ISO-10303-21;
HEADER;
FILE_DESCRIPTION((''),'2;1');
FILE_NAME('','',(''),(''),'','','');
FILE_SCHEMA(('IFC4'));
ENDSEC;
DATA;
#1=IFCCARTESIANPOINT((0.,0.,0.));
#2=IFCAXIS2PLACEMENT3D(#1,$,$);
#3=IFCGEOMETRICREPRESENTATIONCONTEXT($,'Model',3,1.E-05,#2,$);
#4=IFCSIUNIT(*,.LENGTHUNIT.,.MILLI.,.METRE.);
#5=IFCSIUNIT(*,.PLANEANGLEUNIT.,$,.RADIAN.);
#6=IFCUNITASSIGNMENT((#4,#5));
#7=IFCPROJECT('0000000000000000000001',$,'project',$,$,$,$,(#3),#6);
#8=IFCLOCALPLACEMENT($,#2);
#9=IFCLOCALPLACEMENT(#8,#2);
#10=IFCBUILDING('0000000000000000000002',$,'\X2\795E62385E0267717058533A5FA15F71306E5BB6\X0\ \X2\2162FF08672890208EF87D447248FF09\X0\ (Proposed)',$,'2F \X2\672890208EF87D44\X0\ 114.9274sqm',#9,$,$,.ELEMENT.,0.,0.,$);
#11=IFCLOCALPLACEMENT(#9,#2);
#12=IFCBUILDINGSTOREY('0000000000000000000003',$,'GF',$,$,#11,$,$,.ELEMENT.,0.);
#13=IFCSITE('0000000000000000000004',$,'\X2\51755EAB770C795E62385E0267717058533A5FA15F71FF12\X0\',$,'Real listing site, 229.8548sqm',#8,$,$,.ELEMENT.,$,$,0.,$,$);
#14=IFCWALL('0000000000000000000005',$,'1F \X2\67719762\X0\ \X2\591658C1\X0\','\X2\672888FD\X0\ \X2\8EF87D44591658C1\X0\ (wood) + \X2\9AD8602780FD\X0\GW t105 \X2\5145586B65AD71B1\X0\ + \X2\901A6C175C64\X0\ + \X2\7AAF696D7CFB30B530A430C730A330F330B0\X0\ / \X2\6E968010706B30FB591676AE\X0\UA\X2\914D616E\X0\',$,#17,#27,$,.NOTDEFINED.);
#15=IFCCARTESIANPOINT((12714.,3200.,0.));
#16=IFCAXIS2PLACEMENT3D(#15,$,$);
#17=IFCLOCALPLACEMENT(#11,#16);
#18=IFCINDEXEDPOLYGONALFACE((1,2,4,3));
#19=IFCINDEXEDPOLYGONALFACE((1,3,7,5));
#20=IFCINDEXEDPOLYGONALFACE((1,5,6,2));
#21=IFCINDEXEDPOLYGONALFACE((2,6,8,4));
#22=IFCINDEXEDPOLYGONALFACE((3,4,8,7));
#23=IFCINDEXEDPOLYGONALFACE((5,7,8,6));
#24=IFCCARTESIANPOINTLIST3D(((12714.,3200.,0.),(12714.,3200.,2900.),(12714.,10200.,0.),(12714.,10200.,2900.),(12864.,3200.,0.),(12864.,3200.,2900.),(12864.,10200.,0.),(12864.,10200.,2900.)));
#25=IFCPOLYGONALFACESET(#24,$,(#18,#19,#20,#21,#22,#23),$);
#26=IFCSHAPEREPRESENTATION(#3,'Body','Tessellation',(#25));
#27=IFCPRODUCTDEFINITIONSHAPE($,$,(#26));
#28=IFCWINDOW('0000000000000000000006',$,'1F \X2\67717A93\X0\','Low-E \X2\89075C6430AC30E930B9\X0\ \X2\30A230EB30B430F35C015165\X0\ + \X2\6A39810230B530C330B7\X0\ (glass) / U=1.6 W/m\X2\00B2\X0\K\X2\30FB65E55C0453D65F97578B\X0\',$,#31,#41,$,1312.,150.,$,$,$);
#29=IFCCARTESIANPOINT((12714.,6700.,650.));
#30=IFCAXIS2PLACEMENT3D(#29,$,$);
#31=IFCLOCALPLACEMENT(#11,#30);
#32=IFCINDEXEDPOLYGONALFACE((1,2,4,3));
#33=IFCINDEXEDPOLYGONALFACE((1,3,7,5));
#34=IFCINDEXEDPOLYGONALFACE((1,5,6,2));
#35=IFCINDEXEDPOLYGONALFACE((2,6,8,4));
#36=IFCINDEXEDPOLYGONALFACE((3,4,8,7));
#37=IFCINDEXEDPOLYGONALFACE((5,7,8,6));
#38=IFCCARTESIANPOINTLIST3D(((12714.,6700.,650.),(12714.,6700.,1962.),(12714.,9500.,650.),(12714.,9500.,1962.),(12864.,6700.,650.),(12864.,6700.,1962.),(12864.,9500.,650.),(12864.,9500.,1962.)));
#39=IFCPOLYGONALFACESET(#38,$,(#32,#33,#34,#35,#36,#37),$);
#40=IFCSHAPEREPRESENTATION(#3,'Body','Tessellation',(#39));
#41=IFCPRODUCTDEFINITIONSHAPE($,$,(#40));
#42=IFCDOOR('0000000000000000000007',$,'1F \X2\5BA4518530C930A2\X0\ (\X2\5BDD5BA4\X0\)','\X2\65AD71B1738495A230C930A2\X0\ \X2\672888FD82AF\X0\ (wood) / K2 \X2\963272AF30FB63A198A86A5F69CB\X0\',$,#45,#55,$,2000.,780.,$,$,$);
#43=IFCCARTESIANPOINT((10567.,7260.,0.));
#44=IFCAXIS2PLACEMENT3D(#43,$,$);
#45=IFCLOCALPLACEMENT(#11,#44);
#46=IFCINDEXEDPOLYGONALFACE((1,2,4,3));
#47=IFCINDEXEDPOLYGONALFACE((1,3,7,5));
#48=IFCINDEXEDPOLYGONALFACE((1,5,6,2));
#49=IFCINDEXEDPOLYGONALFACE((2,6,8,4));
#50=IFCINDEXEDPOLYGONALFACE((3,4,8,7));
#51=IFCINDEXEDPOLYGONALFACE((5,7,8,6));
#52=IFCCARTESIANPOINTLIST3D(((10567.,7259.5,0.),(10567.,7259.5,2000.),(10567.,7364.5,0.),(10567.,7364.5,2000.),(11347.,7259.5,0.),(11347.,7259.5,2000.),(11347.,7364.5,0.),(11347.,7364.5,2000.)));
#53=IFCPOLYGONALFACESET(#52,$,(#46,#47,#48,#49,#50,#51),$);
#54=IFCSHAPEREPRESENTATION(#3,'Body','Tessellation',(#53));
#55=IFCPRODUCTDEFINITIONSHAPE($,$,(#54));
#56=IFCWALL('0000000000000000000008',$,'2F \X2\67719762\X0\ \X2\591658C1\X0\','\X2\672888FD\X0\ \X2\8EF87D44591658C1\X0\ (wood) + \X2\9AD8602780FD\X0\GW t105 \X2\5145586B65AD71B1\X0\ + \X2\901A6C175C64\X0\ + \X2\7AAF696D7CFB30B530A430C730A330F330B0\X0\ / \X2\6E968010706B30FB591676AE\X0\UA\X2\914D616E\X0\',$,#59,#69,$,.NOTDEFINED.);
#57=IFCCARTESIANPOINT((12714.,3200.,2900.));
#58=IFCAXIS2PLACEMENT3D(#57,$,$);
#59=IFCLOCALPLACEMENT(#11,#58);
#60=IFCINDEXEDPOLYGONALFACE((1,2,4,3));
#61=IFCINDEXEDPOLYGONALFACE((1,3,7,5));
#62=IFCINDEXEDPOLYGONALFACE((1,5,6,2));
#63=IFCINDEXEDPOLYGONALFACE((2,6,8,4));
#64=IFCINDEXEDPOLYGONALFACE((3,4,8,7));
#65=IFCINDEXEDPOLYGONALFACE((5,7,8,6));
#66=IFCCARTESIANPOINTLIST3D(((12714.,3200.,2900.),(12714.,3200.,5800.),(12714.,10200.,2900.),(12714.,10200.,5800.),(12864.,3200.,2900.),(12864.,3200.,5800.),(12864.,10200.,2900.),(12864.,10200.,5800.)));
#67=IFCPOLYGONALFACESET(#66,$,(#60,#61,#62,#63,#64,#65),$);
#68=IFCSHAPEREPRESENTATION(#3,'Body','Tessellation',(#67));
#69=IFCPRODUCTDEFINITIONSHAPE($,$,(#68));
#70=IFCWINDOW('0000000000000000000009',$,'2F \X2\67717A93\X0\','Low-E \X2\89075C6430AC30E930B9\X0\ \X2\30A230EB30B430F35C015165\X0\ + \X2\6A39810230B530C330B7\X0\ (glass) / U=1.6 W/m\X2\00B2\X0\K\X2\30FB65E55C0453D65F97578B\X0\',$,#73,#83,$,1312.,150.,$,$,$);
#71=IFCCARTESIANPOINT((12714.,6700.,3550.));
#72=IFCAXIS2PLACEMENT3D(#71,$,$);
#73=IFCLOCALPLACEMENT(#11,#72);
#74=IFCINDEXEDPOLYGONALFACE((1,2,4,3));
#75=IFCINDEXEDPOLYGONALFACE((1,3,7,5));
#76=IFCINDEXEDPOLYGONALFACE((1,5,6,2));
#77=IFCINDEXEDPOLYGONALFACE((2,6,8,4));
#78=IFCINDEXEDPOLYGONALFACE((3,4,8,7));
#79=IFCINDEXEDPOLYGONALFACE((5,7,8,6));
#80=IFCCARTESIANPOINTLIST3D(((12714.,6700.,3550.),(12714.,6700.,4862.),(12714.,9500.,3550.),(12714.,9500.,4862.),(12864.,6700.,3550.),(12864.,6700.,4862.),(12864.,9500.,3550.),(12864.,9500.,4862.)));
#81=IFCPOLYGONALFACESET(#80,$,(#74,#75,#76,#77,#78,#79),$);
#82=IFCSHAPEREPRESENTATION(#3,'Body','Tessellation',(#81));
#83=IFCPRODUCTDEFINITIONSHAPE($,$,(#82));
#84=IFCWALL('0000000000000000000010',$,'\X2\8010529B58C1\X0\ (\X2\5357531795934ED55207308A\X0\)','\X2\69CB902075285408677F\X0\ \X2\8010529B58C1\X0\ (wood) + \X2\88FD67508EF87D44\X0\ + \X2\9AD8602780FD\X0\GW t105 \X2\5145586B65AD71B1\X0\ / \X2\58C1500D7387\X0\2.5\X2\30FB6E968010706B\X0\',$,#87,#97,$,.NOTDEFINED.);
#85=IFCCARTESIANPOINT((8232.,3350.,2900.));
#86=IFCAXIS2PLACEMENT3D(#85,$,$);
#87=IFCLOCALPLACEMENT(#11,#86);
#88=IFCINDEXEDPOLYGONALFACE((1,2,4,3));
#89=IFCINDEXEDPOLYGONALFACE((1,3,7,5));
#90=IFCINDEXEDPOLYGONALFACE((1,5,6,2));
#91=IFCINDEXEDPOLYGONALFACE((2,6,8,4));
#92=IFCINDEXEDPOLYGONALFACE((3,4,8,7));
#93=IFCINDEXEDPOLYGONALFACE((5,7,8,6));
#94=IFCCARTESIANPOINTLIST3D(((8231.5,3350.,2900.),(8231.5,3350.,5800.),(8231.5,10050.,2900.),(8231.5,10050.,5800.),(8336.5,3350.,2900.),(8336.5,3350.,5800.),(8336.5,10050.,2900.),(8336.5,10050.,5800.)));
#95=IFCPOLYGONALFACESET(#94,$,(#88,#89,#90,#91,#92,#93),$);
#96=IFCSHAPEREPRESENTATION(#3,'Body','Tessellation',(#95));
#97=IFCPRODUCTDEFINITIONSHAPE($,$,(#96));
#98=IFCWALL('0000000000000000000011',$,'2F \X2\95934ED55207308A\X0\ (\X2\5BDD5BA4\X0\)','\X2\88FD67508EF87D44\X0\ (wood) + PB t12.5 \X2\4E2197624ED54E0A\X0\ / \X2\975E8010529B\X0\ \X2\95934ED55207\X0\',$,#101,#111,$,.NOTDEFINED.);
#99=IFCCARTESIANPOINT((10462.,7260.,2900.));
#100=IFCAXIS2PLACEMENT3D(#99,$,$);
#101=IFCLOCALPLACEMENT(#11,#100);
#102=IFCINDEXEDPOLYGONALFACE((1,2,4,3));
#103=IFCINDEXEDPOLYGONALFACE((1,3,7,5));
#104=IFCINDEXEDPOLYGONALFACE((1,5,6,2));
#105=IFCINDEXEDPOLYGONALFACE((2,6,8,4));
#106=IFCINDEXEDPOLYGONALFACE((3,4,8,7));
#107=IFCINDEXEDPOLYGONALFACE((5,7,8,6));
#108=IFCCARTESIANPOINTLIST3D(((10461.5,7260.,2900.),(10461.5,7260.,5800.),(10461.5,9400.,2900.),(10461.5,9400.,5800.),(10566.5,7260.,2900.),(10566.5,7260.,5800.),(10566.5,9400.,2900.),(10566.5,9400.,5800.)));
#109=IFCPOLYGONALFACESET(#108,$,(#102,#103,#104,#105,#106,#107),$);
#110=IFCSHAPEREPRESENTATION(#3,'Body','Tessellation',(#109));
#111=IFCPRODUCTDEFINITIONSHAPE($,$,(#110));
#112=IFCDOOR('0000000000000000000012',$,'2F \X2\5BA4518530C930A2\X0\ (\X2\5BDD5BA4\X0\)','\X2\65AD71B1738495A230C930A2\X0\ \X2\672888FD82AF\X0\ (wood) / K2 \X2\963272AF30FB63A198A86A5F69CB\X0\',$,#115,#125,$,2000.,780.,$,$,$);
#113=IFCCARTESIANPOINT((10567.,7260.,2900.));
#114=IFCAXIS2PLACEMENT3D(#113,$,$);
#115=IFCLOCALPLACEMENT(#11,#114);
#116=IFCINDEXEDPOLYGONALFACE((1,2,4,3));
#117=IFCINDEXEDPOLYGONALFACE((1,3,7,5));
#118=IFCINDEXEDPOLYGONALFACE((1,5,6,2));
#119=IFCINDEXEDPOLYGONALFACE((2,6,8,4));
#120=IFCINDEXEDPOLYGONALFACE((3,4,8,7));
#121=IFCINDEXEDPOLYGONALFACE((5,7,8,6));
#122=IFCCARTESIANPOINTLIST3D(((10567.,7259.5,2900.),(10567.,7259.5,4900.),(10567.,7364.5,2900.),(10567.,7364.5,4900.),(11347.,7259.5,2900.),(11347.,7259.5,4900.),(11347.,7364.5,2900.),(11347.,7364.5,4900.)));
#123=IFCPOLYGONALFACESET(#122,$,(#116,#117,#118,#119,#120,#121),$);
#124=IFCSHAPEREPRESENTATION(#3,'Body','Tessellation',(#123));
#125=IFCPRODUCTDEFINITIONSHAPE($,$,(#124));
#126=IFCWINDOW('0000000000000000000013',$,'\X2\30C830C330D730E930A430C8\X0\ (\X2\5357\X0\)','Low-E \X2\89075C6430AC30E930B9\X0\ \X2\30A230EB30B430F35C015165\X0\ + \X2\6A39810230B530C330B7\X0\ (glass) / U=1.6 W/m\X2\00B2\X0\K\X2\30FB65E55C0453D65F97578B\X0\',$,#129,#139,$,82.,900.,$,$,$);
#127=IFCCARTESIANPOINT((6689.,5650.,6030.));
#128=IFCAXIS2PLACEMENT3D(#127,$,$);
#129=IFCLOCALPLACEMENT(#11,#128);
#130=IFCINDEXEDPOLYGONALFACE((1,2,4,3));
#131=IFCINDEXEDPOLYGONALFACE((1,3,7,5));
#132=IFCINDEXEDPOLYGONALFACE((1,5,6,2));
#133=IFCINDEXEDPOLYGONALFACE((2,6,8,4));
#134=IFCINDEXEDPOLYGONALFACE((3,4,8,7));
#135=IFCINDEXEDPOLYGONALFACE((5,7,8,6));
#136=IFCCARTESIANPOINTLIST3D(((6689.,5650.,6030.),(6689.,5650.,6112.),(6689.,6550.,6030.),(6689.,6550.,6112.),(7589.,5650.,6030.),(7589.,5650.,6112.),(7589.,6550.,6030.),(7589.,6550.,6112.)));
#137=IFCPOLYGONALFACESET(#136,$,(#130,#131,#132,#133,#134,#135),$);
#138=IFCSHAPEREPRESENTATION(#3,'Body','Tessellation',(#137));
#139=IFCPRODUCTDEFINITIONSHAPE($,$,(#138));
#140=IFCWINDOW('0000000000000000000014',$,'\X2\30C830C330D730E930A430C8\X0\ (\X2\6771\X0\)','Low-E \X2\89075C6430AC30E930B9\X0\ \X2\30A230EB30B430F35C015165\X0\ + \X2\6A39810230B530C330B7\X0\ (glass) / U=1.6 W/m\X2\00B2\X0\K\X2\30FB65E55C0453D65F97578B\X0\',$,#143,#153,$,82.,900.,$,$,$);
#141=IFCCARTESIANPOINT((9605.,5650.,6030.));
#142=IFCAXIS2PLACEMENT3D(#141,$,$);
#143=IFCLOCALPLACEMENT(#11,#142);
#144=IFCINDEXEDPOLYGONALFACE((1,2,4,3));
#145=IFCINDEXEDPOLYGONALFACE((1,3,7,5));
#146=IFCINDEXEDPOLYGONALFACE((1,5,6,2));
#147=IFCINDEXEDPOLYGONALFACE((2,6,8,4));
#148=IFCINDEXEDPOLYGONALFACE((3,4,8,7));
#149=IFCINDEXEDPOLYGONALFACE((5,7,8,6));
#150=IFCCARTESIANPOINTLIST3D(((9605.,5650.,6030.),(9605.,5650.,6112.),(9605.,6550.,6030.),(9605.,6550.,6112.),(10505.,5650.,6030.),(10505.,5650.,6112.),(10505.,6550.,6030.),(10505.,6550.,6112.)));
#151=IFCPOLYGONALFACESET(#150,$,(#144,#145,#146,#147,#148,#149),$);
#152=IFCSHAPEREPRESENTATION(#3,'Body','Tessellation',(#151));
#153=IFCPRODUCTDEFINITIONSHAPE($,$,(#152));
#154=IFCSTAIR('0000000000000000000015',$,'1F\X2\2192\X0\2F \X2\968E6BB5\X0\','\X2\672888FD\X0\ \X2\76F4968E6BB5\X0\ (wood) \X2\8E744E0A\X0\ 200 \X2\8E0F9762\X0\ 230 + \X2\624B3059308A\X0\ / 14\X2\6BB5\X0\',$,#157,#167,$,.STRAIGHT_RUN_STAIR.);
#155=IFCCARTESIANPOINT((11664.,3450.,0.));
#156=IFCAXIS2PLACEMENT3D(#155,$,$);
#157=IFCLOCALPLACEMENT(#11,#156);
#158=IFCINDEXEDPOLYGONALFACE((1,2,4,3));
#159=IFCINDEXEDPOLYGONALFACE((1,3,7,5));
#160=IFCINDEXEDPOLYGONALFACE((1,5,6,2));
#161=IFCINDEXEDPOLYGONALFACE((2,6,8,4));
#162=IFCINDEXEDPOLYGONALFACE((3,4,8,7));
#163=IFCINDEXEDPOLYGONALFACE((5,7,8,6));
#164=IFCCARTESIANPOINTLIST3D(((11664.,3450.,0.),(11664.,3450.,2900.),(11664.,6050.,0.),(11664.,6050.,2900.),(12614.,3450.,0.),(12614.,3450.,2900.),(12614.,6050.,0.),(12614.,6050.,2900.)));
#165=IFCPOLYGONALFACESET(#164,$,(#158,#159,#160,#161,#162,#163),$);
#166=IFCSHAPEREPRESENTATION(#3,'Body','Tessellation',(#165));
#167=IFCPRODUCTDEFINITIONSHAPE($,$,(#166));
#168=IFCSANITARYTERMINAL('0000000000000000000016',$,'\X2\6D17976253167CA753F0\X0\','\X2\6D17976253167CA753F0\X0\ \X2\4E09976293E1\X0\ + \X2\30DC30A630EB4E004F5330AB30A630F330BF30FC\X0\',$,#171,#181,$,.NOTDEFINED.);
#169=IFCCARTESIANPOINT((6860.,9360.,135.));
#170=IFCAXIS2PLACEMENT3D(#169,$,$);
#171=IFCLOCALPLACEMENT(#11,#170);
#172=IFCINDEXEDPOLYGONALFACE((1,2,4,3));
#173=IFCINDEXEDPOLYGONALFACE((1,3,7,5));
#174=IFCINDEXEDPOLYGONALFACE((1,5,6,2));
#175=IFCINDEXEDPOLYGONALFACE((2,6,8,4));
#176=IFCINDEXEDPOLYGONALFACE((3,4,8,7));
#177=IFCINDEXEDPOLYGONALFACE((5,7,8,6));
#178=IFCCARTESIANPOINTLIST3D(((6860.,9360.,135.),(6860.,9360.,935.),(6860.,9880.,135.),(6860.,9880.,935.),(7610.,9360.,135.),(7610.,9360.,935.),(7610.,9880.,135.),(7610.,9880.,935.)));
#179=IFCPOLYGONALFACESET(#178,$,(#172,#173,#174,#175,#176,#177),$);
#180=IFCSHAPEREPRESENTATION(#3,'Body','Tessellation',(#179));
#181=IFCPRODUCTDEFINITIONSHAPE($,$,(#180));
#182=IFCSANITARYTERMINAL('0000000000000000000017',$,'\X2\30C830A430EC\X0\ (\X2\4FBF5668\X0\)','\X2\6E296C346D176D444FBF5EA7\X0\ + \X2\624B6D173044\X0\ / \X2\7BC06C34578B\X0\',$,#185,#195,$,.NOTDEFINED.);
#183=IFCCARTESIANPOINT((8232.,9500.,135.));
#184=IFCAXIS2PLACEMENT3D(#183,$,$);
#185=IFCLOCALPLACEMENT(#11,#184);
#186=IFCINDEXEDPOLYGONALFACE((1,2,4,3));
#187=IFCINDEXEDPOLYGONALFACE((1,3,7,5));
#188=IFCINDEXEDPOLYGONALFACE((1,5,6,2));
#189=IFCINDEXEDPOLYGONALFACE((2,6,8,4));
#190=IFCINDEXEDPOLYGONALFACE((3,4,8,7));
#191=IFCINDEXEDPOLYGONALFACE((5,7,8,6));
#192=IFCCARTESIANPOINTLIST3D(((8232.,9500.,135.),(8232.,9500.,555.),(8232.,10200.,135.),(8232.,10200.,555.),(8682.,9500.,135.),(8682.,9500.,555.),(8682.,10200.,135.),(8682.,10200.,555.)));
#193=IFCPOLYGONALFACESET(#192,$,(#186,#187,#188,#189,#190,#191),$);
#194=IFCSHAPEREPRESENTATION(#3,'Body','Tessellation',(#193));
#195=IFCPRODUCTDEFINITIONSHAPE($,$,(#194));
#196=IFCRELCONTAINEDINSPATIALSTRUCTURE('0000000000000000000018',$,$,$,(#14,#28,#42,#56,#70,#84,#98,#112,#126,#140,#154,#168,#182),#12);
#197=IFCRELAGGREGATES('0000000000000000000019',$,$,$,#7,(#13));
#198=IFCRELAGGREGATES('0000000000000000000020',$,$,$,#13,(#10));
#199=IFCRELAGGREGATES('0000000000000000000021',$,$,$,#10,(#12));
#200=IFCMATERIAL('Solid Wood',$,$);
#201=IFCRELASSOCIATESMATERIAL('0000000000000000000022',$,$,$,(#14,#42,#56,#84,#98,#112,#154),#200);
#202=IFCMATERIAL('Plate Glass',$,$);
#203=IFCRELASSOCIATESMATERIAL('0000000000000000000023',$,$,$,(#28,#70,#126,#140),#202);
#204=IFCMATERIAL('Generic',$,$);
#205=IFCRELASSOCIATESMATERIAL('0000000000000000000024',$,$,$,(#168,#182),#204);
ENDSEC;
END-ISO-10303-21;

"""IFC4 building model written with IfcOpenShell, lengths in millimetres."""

from ifc_helpers import new_model, si_unit, frame, frame_2d, origin, place, context, project, spatial, rectangle, extrude, material, element, fill, save


model = new_model("IFC4")

# Units and contexts
model_context = context("Model", 3, precision=1e-05, world=origin())
ifc_project = project(units=[si_unit("LENGTHUNIT", "METRE", prefix="MILLI"), si_unit("PLANEANGLEUNIT", "RADIAN")], contexts=[model_context])

# Site, building, storey
site_placement = place(None, origin())
site = spatial("IfcSite", under=ifc_project, at=site_placement, Name="兵庫県神戸市東灘区御影２", ObjectType="Real listing site, 229.8548sqm", CompositionType="ELEMENT", RefElevation=0.0)
building_placement = place(site_placement, origin())
building = spatial("IfcBuilding", under=site, at=building_placement, Name="神戸市東灘区御影の家 Ⅲ（木造軸組版） (Proposed)", ObjectType="2F 木造軸組 114.9274sqm", CompositionType="ELEMENT", ElevationOfRefHeight=0.0, ElevationOfTerrain=0.0)
storey_placement = place(building_placement, origin())
storey = spatial("IfcBuildingStorey", under=building, at=storey_placement, Name="GF", CompositionType="ELEMENT", Elevation=0.0)

# Wall, opening, window
ifc_material_1 = material(Name="Solid Wood")
wall_1_placement = place(storey_placement, frame((12714.0, 3200.0, 0.0)))
wall_1 = element("IfcWall", 1, at=wall_1_placement, inside=storey, material=ifc_material_1, Name="1F 東面 外壁", Description="木製 軸組外壁 (wood) + 高性能GW t105 充填断熱 + 通気層 + 窯業系サイディング / 準耐火・外皮UA配慮", PredefinedType="NOTDEFINED", context=model_context, shape_type="SweptSolid", body=[
    extrude(rectangle(XDim=150.0, YDim=7000.0, at=frame_2d((75.0, 3500.0))), frame((12714.0, 3200.0, 0.0)), (0.0, 0.0, 1.0), 2900.0),
])
opening_1_placement = place(storey_placement, frame((12714.0, 6700.0, 650.0)))
opening_1 = element("IfcOpeningElement", 2, at=opening_1_placement, cuts=wall_1, PredefinedType="NOTDEFINED", context=model_context, shape_type="SweptSolid", body=[
    extrude(rectangle(XDim=150.0, YDim=2800.0, at=frame_2d((75.0, 1400.0))), frame((12714.0, 6700.0, 650.0)), (0.0, 0.0, 1.0), 1312.0),
])
ifc_material_2 = material(Name="Plate Glass")
window_1_placement = place(storey_placement, frame((12714.0, 6700.0, 650.0)))
window_1 = element("IfcWindow", 3, at=window_1_placement, inside=storey, material=ifc_material_2, Name="1F 東窓", Description="Low-E 複層ガラス アルゴン封入 + 樹脂サッシ (glass) / U=1.6 W/m²K・日射取得型", OverallHeight=1312.0, OverallWidth=150.0, context=model_context, shape_type="SweptSolid", body=[
    extrude(rectangle(XDim=150.0, YDim=2800.0, at=frame_2d((75.0, 1400.0))), frame((12714.0, 6700.0, 650.0)), (0.0, 0.0, 1.0), 1312.0),
])
fill(opening_1, window_1)

# Door
door_1_placement = place(storey_placement, frame((10567.0, 7260.0, 0.0)))
element("IfcDoor", 4, at=door_1_placement, inside=storey, material=ifc_material_1, Name="1F 室内ドア (寝室)", Description="断熱玄関ドア 木製芯 (wood) / K2 防犯・採風機構", OverallHeight=2000.0, OverallWidth=780.0, context=model_context, shape_type="SweptSolid", body=[
    extrude(rectangle(XDim=780.0, YDim=105.0, at=frame_2d((390.0, 52.0))), frame((10567.0, 7260.0, 0.0)), (0.0, 0.0, 1.0), 2000.0),
])

# Wall, opening, window
wall_2_placement = place(storey_placement, frame((12714.0, 3200.0, 2900.0)))
wall_2 = element("IfcWall", 5, at=wall_2_placement, inside=storey, material=ifc_material_1, Name="2F 東面 外壁", Description="木製 軸組外壁 (wood) + 高性能GW t105 充填断熱 + 通気層 + 窯業系サイディング / 準耐火・外皮UA配慮", PredefinedType="NOTDEFINED", context=model_context, shape_type="SweptSolid", body=[
    extrude(rectangle(XDim=150.0, YDim=7000.0, at=frame_2d((75.0, 3500.0))), frame((12714.0, 3200.0, 2900.0)), (0.0, 0.0, 1.0), 2900.0),
])
opening_2_placement = place(storey_placement, frame((12714.0, 6700.0, 3550.0)))
opening_2 = element("IfcOpeningElement", 6, at=opening_2_placement, cuts=wall_2, PredefinedType="NOTDEFINED", context=model_context, shape_type="SweptSolid", body=[
    extrude(rectangle(XDim=150.0, YDim=2800.0, at=frame_2d((75.0, 1400.0))), frame((12714.0, 6700.0, 3550.0)), (0.0, 0.0, 1.0), 1312.0),
])
window_2_placement = place(storey_placement, frame((12714.0, 6700.0, 3550.0)))
window_2 = element("IfcWindow", 7, at=window_2_placement, inside=storey, material=ifc_material_2, Name="2F 東窓", Description="Low-E 複層ガラス アルゴン封入 + 樹脂サッシ (glass) / U=1.6 W/m²K・日射取得型", OverallHeight=1312.0, OverallWidth=150.0, context=model_context, shape_type="SweptSolid", body=[
    extrude(rectangle(XDim=150.0, YDim=2800.0, at=frame_2d((75.0, 1400.0))), frame((12714.0, 6700.0, 3550.0)), (0.0, 0.0, 1.0), 1312.0),
])
fill(opening_2, window_2)

# Walls
wall_3_placement = place(storey_placement, frame((8232.0, 3350.0, 2900.0)))
element("IfcWall", 8, at=wall_3_placement, inside=storey, material=ifc_material_1, Name="耐力壁 (南北間仕切り)", Description="構造用合板 耐力壁 (wood) + 製材軸組 + 高性能GW t105 充填断熱 / 壁倍率2.5・準耐火", PredefinedType="NOTDEFINED", context=model_context, shape_type="SweptSolid", body=[
    extrude(rectangle(XDim=105.0, YDim=6700.0, at=frame_2d((52.0, 3350.0))), frame((8232.0, 3350.0, 2900.0)), (0.0, 0.0, 1.0), 2900.0),
])
wall_4_placement = place(storey_placement, frame((10462.0, 7260.0, 2900.0)))
element("IfcWall", 9, at=wall_4_placement, inside=storey, material=ifc_material_1, Name="2F 間仕切り (寝室)", Description="製材軸組 (wood) + PB t12.5 両面仕上 / 非耐力 間仕切", PredefinedType="NOTDEFINED", context=model_context, shape_type="SweptSolid", body=[
    extrude(rectangle(XDim=105.0, YDim=2140.0, at=frame_2d((52.0, 1070.0))), frame((10462.0, 7260.0, 2900.0)), (0.0, 0.0, 1.0), 2900.0),
])

# Door
door_2_placement = place(storey_placement, frame((10567.0, 7260.0, 2900.0)))
element("IfcDoor", 10, at=door_2_placement, inside=storey, material=ifc_material_1, Name="2F 室内ドア (寝室)", Description="断熱玄関ドア 木製芯 (wood) / K2 防犯・採風機構", OverallHeight=2000.0, OverallWidth=780.0, context=model_context, shape_type="SweptSolid", body=[
    extrude(rectangle(XDim=780.0, YDim=105.0, at=frame_2d((390.0, 52.0))), frame((10567.0, 7260.0, 2900.0)), (0.0, 0.0, 1.0), 2000.0),
])

# Windows
window_3_placement = place(storey_placement, frame((6689.0, 5650.0, 6030.0)))
element("IfcWindow", 11, at=window_3_placement, inside=storey, material=ifc_material_2, Name="トップライト (南)", Description="Low-E 複層ガラス アルゴン封入 + 樹脂サッシ (glass) / U=1.6 W/m²K・日射取得型", OverallHeight=82.0, OverallWidth=900.0, context=model_context, shape_type="SweptSolid", body=[
    extrude(rectangle(XDim=900.0, YDim=900.0, at=frame_2d((450.0, 450.0))), frame((6689.0, 5650.0, 6030.0)), (0.0, 0.0, 1.0), 82.0),
])
window_4_placement = place(storey_placement, frame((9605.0, 5650.0, 6030.0)))
element("IfcWindow", 12, at=window_4_placement, inside=storey, material=ifc_material_2, Name="トップライト (東)", Description="Low-E 複層ガラス アルゴン封入 + 樹脂サッシ (glass) / U=1.6 W/m²K・日射取得型", OverallHeight=82.0, OverallWidth=900.0, context=model_context, shape_type="SweptSolid", body=[
    extrude(rectangle(XDim=900.0, YDim=900.0, at=frame_2d((450.0, 450.0))), frame((9605.0, 5650.0, 6030.0)), (0.0, 0.0, 1.0), 82.0),
])

# Stair
stair_placement = place(storey_placement, frame((11664.0, 3450.0, 0.0)))
element("IfcStair", 13, at=stair_placement, inside=storey, material=ifc_material_1, Name="1F→2F 階段", Description="木製 直階段 (wood) 蹴上 200 踏面 230 + 手すり / 14段", PredefinedType="STRAIGHT_RUN_STAIR", context=model_context, shape_type="SweptSolid", body=[
    extrude(rectangle(XDim=950.0, YDim=2600.0, at=frame_2d((475.0, 1300.0))), frame((11664.0, 3450.0, 0.0)), (0.0, 0.0, 1.0), 2900.0),
])

# Sanitary terminals
ifc_material_3 = material(Name="Generic")
sanitary_terminal_1_placement = place(storey_placement, frame((6860.0, 9360.0, 135.0)))
element("IfcSanitaryTerminal", 14, at=sanitary_terminal_1_placement, inside=storey, material=ifc_material_3, Name="洗面化粧台", Description="洗面化粧台 三面鏡 + ボウル一体カウンター", PredefinedType="NOTDEFINED", context=model_context, shape_type="SweptSolid", body=[
    extrude(rectangle(XDim=750.0, YDim=520.0, at=frame_2d((375.0, 260.0))), frame((6860.0, 9360.0, 135.0)), (0.0, 0.0, 1.0), 800.0),
])
sanitary_terminal_2_placement = place(storey_placement, frame((8232.0, 9500.0, 135.0)))
element("IfcSanitaryTerminal", 15, at=sanitary_terminal_2_placement, inside=storey, material=ifc_material_3, Name="トイレ (便器)", Description="温水洗浄便座 + 手洗い / 節水型", PredefinedType="NOTDEFINED", context=model_context, shape_type="SweptSolid", body=[
    extrude(rectangle(XDim=450.0, YDim=700.0, at=frame_2d((225.0, 350.0))), frame((8232.0, 9500.0, 135.0)), (0.0, 0.0, 1.0), 420.0),
])

save(model, "model.ifc")
